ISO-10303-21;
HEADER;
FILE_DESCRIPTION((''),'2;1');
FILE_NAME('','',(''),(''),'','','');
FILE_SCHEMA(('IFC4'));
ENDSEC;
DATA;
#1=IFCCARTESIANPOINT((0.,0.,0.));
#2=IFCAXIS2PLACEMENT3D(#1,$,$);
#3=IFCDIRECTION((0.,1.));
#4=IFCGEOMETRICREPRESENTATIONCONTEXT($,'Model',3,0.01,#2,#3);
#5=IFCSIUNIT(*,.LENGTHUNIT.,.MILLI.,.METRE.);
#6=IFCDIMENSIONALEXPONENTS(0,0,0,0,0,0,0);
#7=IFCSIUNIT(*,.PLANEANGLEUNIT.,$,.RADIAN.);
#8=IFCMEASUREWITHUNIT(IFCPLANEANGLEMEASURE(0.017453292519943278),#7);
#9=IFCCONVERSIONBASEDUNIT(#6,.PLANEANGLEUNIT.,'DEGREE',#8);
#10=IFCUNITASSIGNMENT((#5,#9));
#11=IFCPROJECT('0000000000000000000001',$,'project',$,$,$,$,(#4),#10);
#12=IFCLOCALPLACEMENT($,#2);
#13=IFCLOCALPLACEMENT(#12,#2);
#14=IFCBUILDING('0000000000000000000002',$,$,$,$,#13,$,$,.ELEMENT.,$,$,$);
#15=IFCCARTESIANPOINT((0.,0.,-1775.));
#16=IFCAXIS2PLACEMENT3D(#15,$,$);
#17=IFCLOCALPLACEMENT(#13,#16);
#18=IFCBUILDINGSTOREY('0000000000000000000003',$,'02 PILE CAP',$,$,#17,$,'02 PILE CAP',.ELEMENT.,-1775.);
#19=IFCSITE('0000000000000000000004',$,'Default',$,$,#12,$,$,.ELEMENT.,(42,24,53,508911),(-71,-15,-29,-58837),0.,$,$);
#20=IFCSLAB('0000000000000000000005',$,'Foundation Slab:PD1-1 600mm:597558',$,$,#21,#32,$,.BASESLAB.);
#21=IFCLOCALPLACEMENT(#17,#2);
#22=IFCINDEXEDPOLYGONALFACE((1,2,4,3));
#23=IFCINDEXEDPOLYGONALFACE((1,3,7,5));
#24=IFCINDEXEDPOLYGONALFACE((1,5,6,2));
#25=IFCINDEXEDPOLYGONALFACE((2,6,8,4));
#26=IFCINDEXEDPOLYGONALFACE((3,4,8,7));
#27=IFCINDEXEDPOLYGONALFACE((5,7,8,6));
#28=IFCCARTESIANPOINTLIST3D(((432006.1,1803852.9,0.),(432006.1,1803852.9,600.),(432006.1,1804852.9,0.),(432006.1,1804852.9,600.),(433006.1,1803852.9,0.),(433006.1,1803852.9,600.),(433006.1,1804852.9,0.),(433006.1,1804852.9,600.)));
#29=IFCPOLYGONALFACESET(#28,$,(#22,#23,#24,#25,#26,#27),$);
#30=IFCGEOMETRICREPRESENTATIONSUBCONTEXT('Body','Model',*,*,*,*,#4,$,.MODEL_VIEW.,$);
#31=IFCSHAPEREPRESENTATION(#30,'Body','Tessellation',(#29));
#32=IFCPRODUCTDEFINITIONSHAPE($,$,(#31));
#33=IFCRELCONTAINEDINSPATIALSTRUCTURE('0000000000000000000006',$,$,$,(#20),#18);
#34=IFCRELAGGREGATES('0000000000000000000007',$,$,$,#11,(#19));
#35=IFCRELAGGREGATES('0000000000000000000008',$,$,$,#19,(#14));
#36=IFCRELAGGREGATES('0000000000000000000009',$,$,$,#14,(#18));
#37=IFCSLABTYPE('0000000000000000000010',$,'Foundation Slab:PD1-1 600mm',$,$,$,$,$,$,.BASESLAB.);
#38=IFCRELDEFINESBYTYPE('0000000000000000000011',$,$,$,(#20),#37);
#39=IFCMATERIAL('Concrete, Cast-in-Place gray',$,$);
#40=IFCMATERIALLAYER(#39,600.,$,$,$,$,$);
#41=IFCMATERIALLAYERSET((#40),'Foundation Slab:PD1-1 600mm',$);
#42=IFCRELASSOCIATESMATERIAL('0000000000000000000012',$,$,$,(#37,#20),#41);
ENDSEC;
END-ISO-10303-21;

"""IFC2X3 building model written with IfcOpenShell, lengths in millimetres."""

from ifc_helpers import new_model, entity, si_unit, converted_unit, direction, frame, frame_2d, origin, place, context, subcontext, project, spatial, rectangle, extrude, material, layer, layer_set, layer_usage, type_object, element, save


model = new_model("IFC2X3")

# Units and contexts
model_context = context("Model", 3, precision=0.01, world=origin(), true_north=direction((0.0, 1.0)))
body_context = subcontext(model_context, "Body", "Model", "MODEL_VIEW")
ifc_project = project(units=[si_unit("LENGTHUNIT", "METRE", prefix="MILLI"), converted_unit("PLANEANGLEUNIT", "DEGREE", entity("IfcPlaneAngleMeasure", 0.017453292519943278), si_unit("PLANEANGLEUNIT", "RADIAN"), dimensions=[0, 0, 0, 0, 0, 0, 0])], contexts=[model_context])

# Site, building, storey
site_placement = place(None, origin())
site = spatial("IfcSite", under=ifc_project, at=site_placement, Name="Default", CompositionType="ELEMENT", RefLatitude=(42, 24, 53, 508911), RefLongitude=(-71, -15, -29, -58837), RefElevation=0.0)
building_placement = place(site_placement, origin())
building = spatial("IfcBuilding", under=site, at=building_placement, CompositionType="ELEMENT")
storey_placement = place(building_placement, frame((0.0, 0.0, -1775.0)))
storey = spatial("IfcBuildingStorey", under=building, at=storey_placement, Name="02 PILE CAP", LongName="02 PILE CAP", CompositionType="ELEMENT", Elevation=-1775.0)

# Shared definitions
ifc_material_1 = material(Name="Concrete, Cast-in-Place gray")

# Shared definitions
ifc_layer = layer(ifc_material_1, 600.0)
ifc_layer_set = layer_set([ifc_layer], Name="Foundation Slab:PD1-1 600mm")
slab_type_1 = type_object("IfcSlabType", Name="Foundation Slab:PD1-1 600mm", PredefinedType="BASESLAB", material=ifc_layer_set)

# Slab
ifc_layer_usage_1 = layer_usage(ifc_layer_set, "AXIS3", "POSITIVE", 0.0)
slab_1_placement = place(storey_placement, origin())
element("IfcSlab", 1, at=slab_1_placement, inside=storey, type_object=slab_type_1, material=ifc_layer_usage_1, Name="Foundation Slab:PD1-1 600mm:597558", PredefinedType="BASESLAB", context=body_context, shape_type="SweptSolid", body=[
    extrude(rectangle(XDim=1000.0, YDim=1000.0, at=frame_2d((0.0, 0.0), x_axis=(1.0, 0.0))), frame((432506.1, 1804352.9, 600.0), z_axis=(0.0, 0.0, -1.0), x_axis=(0.0, 1.0, 0.0)), (0.0, 0.0, 1.0), 600.0),
])

save(model, "model.ifc")
